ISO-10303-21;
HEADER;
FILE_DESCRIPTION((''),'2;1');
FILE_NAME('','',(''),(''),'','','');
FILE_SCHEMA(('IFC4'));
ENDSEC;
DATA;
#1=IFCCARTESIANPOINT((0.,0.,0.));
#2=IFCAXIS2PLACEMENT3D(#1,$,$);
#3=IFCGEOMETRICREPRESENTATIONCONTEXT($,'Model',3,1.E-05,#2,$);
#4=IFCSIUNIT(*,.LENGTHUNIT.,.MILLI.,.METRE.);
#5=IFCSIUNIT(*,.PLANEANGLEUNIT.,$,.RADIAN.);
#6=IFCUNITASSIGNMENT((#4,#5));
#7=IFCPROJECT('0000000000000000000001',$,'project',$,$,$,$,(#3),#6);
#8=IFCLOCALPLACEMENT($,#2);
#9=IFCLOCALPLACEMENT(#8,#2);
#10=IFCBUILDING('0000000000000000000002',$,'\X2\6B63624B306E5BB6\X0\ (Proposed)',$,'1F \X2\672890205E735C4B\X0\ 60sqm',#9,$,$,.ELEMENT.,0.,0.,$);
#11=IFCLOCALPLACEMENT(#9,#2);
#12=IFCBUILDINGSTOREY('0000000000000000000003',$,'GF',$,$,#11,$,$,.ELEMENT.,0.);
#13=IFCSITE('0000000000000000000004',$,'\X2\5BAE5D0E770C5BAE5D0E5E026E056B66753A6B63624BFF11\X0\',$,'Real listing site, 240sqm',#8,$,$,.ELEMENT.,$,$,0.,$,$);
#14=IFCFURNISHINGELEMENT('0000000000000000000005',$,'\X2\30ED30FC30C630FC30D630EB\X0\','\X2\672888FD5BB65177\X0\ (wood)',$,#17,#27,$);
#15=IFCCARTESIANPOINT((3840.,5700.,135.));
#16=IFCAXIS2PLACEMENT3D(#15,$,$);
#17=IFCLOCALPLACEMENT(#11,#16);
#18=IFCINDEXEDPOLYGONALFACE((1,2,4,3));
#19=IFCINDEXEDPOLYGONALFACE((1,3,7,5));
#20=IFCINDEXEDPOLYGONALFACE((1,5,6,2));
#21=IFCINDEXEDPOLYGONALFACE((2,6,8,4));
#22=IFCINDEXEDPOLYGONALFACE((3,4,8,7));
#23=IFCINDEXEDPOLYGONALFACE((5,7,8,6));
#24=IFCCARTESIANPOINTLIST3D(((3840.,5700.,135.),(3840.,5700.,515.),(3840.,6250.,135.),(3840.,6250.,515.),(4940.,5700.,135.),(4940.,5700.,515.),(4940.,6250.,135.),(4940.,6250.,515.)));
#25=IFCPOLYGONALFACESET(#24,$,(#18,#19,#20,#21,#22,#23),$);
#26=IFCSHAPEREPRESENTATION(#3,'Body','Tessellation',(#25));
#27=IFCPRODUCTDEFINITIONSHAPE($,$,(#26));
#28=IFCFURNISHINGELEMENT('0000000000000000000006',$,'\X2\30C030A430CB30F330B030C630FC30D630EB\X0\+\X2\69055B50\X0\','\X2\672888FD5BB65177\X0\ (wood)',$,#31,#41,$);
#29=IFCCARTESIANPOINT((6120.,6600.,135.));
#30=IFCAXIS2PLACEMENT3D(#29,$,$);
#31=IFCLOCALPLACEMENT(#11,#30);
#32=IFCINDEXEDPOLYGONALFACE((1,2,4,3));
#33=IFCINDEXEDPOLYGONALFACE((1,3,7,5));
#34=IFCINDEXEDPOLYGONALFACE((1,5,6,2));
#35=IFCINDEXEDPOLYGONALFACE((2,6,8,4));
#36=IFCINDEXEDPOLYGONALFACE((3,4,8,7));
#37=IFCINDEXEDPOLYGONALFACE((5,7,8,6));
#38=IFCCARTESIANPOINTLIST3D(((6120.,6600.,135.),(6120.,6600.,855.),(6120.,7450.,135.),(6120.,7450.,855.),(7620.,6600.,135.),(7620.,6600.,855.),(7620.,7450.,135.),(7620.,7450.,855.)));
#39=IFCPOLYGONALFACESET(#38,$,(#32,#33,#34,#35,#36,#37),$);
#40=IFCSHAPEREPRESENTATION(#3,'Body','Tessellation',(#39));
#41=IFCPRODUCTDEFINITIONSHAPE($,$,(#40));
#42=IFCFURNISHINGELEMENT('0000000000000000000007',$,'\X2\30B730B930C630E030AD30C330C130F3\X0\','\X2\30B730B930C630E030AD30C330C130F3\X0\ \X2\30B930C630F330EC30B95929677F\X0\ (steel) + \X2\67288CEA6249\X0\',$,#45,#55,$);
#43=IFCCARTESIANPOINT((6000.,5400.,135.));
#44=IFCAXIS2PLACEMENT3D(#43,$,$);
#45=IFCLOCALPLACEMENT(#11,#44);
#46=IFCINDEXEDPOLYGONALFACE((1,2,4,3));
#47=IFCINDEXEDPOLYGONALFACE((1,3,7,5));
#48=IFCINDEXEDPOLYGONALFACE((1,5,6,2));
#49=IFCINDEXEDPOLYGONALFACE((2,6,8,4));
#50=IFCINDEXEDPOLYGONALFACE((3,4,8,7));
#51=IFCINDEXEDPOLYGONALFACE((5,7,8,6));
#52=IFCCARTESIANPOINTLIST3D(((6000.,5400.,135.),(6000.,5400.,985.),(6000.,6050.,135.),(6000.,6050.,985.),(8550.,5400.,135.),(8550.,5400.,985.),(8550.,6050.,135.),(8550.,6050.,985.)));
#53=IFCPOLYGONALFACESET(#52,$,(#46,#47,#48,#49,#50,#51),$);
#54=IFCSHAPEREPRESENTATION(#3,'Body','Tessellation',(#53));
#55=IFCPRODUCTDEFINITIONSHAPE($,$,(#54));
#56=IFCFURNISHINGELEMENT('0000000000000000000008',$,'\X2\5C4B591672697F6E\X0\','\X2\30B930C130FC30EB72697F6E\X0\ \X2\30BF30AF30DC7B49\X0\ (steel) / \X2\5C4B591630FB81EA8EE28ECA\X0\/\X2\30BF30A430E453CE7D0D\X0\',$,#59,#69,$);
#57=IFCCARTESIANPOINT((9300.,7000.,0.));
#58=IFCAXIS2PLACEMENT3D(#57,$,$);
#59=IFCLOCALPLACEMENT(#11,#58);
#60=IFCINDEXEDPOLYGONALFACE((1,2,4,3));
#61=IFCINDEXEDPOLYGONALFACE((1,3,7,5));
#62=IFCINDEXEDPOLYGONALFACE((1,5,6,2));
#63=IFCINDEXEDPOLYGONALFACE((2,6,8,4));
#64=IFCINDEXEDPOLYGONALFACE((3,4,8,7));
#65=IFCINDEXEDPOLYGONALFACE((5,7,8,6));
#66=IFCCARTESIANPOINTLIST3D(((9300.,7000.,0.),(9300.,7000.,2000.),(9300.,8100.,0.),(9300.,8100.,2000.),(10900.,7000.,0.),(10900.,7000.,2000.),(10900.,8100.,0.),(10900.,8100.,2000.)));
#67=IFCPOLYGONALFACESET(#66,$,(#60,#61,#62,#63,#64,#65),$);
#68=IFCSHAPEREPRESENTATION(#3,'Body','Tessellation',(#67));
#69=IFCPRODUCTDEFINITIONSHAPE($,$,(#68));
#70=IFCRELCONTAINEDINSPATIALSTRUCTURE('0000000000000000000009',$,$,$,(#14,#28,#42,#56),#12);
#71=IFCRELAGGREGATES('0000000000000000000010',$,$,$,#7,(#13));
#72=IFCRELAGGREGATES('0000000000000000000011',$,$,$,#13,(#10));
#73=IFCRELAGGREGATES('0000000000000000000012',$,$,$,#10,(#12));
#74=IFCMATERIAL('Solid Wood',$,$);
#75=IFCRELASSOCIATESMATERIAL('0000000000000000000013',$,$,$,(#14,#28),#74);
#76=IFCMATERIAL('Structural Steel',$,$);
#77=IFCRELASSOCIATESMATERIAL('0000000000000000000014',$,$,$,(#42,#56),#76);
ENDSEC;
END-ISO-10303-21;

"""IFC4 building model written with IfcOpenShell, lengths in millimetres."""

from ifc_helpers import new_model, si_unit, frame, frame_2d, origin, place, context, project, spatial, rectangle, extrude, material, element, save


model = new_model("IFC4")

# Units and contexts
model_context = context("Model", 3, precision=1e-05, world=origin())
ifc_project = project(units=[si_unit("LENGTHUNIT", "METRE", prefix="MILLI"), si_unit("PLANEANGLEUNIT", "RADIAN")], contexts=[model_context])

# Site, building, storey
site_placement = place(None, origin())
site = spatial("IfcSite", under=ifc_project, at=site_placement, Name="宮崎県宮崎市清武町正手１", ObjectType="Real listing site, 240sqm", CompositionType="ELEMENT", RefElevation=0.0)
building_placement = place(site_placement, origin())
building = spatial("IfcBuilding", under=site, at=building_placement, Name="正手の家 (Proposed)", ObjectType="1F 木造平屋 60sqm", CompositionType="ELEMENT", ElevationOfRefHeight=0.0, ElevationOfTerrain=0.0)
storey_placement = place(building_placement, origin())
storey = spatial("IfcBuildingStorey", under=building, at=storey_placement, Name="GF", CompositionType="ELEMENT", Elevation=0.0)

# Shared definitions
ifc_material_1 = material(Name="Solid Wood")

# Shared definitions
ifc_material_2 = material(Name="Structural Steel")

# Furnishing elements
furnishing_1_placement = place(storey_placement, frame((3840.0, 5700.0, 135.0)))
element("IfcFurnishingElement", 1, at=furnishing_1_placement, inside=storey, material=ifc_material_1, Name="ローテーブル", Description="木製家具 (wood)", context=model_context, shape_type="SweptSolid", body=[
    extrude(rectangle(XDim=1100.0, YDim=550.0, at=frame_2d((550.0, 275.0))), frame((3840.0, 5700.0, 135.0)), (0.0, 0.0, 1.0), 380.0),
])
furnishing_2_placement = place(storey_placement, frame((6120.0, 6600.0, 135.0)))
element("IfcFurnishingElement", 2, at=furnishing_2_placement, inside=storey, material=ifc_material_1, Name="ダイニングテーブル+椅子", Description="木製家具 (wood)", context=model_context, shape_type="SweptSolid", body=[
    extrude(rectangle(XDim=1500.0, YDim=850.0, at=frame_2d((750.0, 425.0))), frame((6120.0, 6600.0, 135.0)), (0.0, 0.0, 1.0), 720.0),
])
furnishing_3_placement = place(storey_placement, frame((6000.0, 5400.0, 135.0)))
element("IfcFurnishingElement", 3, at=furnishing_3_placement, inside=storey, material=ifc_material_2, Name="システムキッチン", Description="システムキッチン ステンレス天板 (steel) + 木質扉", context=model_context, shape_type="SweptSolid", body=[
    extrude(rectangle(XDim=2550.0, YDim=650.0, at=frame_2d((1275.0, 325.0))), frame((6000.0, 5400.0, 135.0)), (0.0, 0.0, 1.0), 850.0),
])
furnishing_4_placement = place(storey_placement, frame((9300.0, 7000.0, 0.0)))
element("IfcFurnishingElement", 4, at=furnishing_4_placement, inside=storey, material=ifc_material_2, Name="屋外物置", Description="スチール物置 タクボ等 (steel) / 屋外・自転車/タイヤ収納", context=model_context, shape_type="SweptSolid", body=[
    extrude(rectangle(XDim=1600.0, YDim=1100.0, at=frame_2d((800.0, 550.0))), frame((9300.0, 7000.0, 0.0)), (0.0, 0.0, 1.0), 2000.0),
])

save(model, "model.ifc")
